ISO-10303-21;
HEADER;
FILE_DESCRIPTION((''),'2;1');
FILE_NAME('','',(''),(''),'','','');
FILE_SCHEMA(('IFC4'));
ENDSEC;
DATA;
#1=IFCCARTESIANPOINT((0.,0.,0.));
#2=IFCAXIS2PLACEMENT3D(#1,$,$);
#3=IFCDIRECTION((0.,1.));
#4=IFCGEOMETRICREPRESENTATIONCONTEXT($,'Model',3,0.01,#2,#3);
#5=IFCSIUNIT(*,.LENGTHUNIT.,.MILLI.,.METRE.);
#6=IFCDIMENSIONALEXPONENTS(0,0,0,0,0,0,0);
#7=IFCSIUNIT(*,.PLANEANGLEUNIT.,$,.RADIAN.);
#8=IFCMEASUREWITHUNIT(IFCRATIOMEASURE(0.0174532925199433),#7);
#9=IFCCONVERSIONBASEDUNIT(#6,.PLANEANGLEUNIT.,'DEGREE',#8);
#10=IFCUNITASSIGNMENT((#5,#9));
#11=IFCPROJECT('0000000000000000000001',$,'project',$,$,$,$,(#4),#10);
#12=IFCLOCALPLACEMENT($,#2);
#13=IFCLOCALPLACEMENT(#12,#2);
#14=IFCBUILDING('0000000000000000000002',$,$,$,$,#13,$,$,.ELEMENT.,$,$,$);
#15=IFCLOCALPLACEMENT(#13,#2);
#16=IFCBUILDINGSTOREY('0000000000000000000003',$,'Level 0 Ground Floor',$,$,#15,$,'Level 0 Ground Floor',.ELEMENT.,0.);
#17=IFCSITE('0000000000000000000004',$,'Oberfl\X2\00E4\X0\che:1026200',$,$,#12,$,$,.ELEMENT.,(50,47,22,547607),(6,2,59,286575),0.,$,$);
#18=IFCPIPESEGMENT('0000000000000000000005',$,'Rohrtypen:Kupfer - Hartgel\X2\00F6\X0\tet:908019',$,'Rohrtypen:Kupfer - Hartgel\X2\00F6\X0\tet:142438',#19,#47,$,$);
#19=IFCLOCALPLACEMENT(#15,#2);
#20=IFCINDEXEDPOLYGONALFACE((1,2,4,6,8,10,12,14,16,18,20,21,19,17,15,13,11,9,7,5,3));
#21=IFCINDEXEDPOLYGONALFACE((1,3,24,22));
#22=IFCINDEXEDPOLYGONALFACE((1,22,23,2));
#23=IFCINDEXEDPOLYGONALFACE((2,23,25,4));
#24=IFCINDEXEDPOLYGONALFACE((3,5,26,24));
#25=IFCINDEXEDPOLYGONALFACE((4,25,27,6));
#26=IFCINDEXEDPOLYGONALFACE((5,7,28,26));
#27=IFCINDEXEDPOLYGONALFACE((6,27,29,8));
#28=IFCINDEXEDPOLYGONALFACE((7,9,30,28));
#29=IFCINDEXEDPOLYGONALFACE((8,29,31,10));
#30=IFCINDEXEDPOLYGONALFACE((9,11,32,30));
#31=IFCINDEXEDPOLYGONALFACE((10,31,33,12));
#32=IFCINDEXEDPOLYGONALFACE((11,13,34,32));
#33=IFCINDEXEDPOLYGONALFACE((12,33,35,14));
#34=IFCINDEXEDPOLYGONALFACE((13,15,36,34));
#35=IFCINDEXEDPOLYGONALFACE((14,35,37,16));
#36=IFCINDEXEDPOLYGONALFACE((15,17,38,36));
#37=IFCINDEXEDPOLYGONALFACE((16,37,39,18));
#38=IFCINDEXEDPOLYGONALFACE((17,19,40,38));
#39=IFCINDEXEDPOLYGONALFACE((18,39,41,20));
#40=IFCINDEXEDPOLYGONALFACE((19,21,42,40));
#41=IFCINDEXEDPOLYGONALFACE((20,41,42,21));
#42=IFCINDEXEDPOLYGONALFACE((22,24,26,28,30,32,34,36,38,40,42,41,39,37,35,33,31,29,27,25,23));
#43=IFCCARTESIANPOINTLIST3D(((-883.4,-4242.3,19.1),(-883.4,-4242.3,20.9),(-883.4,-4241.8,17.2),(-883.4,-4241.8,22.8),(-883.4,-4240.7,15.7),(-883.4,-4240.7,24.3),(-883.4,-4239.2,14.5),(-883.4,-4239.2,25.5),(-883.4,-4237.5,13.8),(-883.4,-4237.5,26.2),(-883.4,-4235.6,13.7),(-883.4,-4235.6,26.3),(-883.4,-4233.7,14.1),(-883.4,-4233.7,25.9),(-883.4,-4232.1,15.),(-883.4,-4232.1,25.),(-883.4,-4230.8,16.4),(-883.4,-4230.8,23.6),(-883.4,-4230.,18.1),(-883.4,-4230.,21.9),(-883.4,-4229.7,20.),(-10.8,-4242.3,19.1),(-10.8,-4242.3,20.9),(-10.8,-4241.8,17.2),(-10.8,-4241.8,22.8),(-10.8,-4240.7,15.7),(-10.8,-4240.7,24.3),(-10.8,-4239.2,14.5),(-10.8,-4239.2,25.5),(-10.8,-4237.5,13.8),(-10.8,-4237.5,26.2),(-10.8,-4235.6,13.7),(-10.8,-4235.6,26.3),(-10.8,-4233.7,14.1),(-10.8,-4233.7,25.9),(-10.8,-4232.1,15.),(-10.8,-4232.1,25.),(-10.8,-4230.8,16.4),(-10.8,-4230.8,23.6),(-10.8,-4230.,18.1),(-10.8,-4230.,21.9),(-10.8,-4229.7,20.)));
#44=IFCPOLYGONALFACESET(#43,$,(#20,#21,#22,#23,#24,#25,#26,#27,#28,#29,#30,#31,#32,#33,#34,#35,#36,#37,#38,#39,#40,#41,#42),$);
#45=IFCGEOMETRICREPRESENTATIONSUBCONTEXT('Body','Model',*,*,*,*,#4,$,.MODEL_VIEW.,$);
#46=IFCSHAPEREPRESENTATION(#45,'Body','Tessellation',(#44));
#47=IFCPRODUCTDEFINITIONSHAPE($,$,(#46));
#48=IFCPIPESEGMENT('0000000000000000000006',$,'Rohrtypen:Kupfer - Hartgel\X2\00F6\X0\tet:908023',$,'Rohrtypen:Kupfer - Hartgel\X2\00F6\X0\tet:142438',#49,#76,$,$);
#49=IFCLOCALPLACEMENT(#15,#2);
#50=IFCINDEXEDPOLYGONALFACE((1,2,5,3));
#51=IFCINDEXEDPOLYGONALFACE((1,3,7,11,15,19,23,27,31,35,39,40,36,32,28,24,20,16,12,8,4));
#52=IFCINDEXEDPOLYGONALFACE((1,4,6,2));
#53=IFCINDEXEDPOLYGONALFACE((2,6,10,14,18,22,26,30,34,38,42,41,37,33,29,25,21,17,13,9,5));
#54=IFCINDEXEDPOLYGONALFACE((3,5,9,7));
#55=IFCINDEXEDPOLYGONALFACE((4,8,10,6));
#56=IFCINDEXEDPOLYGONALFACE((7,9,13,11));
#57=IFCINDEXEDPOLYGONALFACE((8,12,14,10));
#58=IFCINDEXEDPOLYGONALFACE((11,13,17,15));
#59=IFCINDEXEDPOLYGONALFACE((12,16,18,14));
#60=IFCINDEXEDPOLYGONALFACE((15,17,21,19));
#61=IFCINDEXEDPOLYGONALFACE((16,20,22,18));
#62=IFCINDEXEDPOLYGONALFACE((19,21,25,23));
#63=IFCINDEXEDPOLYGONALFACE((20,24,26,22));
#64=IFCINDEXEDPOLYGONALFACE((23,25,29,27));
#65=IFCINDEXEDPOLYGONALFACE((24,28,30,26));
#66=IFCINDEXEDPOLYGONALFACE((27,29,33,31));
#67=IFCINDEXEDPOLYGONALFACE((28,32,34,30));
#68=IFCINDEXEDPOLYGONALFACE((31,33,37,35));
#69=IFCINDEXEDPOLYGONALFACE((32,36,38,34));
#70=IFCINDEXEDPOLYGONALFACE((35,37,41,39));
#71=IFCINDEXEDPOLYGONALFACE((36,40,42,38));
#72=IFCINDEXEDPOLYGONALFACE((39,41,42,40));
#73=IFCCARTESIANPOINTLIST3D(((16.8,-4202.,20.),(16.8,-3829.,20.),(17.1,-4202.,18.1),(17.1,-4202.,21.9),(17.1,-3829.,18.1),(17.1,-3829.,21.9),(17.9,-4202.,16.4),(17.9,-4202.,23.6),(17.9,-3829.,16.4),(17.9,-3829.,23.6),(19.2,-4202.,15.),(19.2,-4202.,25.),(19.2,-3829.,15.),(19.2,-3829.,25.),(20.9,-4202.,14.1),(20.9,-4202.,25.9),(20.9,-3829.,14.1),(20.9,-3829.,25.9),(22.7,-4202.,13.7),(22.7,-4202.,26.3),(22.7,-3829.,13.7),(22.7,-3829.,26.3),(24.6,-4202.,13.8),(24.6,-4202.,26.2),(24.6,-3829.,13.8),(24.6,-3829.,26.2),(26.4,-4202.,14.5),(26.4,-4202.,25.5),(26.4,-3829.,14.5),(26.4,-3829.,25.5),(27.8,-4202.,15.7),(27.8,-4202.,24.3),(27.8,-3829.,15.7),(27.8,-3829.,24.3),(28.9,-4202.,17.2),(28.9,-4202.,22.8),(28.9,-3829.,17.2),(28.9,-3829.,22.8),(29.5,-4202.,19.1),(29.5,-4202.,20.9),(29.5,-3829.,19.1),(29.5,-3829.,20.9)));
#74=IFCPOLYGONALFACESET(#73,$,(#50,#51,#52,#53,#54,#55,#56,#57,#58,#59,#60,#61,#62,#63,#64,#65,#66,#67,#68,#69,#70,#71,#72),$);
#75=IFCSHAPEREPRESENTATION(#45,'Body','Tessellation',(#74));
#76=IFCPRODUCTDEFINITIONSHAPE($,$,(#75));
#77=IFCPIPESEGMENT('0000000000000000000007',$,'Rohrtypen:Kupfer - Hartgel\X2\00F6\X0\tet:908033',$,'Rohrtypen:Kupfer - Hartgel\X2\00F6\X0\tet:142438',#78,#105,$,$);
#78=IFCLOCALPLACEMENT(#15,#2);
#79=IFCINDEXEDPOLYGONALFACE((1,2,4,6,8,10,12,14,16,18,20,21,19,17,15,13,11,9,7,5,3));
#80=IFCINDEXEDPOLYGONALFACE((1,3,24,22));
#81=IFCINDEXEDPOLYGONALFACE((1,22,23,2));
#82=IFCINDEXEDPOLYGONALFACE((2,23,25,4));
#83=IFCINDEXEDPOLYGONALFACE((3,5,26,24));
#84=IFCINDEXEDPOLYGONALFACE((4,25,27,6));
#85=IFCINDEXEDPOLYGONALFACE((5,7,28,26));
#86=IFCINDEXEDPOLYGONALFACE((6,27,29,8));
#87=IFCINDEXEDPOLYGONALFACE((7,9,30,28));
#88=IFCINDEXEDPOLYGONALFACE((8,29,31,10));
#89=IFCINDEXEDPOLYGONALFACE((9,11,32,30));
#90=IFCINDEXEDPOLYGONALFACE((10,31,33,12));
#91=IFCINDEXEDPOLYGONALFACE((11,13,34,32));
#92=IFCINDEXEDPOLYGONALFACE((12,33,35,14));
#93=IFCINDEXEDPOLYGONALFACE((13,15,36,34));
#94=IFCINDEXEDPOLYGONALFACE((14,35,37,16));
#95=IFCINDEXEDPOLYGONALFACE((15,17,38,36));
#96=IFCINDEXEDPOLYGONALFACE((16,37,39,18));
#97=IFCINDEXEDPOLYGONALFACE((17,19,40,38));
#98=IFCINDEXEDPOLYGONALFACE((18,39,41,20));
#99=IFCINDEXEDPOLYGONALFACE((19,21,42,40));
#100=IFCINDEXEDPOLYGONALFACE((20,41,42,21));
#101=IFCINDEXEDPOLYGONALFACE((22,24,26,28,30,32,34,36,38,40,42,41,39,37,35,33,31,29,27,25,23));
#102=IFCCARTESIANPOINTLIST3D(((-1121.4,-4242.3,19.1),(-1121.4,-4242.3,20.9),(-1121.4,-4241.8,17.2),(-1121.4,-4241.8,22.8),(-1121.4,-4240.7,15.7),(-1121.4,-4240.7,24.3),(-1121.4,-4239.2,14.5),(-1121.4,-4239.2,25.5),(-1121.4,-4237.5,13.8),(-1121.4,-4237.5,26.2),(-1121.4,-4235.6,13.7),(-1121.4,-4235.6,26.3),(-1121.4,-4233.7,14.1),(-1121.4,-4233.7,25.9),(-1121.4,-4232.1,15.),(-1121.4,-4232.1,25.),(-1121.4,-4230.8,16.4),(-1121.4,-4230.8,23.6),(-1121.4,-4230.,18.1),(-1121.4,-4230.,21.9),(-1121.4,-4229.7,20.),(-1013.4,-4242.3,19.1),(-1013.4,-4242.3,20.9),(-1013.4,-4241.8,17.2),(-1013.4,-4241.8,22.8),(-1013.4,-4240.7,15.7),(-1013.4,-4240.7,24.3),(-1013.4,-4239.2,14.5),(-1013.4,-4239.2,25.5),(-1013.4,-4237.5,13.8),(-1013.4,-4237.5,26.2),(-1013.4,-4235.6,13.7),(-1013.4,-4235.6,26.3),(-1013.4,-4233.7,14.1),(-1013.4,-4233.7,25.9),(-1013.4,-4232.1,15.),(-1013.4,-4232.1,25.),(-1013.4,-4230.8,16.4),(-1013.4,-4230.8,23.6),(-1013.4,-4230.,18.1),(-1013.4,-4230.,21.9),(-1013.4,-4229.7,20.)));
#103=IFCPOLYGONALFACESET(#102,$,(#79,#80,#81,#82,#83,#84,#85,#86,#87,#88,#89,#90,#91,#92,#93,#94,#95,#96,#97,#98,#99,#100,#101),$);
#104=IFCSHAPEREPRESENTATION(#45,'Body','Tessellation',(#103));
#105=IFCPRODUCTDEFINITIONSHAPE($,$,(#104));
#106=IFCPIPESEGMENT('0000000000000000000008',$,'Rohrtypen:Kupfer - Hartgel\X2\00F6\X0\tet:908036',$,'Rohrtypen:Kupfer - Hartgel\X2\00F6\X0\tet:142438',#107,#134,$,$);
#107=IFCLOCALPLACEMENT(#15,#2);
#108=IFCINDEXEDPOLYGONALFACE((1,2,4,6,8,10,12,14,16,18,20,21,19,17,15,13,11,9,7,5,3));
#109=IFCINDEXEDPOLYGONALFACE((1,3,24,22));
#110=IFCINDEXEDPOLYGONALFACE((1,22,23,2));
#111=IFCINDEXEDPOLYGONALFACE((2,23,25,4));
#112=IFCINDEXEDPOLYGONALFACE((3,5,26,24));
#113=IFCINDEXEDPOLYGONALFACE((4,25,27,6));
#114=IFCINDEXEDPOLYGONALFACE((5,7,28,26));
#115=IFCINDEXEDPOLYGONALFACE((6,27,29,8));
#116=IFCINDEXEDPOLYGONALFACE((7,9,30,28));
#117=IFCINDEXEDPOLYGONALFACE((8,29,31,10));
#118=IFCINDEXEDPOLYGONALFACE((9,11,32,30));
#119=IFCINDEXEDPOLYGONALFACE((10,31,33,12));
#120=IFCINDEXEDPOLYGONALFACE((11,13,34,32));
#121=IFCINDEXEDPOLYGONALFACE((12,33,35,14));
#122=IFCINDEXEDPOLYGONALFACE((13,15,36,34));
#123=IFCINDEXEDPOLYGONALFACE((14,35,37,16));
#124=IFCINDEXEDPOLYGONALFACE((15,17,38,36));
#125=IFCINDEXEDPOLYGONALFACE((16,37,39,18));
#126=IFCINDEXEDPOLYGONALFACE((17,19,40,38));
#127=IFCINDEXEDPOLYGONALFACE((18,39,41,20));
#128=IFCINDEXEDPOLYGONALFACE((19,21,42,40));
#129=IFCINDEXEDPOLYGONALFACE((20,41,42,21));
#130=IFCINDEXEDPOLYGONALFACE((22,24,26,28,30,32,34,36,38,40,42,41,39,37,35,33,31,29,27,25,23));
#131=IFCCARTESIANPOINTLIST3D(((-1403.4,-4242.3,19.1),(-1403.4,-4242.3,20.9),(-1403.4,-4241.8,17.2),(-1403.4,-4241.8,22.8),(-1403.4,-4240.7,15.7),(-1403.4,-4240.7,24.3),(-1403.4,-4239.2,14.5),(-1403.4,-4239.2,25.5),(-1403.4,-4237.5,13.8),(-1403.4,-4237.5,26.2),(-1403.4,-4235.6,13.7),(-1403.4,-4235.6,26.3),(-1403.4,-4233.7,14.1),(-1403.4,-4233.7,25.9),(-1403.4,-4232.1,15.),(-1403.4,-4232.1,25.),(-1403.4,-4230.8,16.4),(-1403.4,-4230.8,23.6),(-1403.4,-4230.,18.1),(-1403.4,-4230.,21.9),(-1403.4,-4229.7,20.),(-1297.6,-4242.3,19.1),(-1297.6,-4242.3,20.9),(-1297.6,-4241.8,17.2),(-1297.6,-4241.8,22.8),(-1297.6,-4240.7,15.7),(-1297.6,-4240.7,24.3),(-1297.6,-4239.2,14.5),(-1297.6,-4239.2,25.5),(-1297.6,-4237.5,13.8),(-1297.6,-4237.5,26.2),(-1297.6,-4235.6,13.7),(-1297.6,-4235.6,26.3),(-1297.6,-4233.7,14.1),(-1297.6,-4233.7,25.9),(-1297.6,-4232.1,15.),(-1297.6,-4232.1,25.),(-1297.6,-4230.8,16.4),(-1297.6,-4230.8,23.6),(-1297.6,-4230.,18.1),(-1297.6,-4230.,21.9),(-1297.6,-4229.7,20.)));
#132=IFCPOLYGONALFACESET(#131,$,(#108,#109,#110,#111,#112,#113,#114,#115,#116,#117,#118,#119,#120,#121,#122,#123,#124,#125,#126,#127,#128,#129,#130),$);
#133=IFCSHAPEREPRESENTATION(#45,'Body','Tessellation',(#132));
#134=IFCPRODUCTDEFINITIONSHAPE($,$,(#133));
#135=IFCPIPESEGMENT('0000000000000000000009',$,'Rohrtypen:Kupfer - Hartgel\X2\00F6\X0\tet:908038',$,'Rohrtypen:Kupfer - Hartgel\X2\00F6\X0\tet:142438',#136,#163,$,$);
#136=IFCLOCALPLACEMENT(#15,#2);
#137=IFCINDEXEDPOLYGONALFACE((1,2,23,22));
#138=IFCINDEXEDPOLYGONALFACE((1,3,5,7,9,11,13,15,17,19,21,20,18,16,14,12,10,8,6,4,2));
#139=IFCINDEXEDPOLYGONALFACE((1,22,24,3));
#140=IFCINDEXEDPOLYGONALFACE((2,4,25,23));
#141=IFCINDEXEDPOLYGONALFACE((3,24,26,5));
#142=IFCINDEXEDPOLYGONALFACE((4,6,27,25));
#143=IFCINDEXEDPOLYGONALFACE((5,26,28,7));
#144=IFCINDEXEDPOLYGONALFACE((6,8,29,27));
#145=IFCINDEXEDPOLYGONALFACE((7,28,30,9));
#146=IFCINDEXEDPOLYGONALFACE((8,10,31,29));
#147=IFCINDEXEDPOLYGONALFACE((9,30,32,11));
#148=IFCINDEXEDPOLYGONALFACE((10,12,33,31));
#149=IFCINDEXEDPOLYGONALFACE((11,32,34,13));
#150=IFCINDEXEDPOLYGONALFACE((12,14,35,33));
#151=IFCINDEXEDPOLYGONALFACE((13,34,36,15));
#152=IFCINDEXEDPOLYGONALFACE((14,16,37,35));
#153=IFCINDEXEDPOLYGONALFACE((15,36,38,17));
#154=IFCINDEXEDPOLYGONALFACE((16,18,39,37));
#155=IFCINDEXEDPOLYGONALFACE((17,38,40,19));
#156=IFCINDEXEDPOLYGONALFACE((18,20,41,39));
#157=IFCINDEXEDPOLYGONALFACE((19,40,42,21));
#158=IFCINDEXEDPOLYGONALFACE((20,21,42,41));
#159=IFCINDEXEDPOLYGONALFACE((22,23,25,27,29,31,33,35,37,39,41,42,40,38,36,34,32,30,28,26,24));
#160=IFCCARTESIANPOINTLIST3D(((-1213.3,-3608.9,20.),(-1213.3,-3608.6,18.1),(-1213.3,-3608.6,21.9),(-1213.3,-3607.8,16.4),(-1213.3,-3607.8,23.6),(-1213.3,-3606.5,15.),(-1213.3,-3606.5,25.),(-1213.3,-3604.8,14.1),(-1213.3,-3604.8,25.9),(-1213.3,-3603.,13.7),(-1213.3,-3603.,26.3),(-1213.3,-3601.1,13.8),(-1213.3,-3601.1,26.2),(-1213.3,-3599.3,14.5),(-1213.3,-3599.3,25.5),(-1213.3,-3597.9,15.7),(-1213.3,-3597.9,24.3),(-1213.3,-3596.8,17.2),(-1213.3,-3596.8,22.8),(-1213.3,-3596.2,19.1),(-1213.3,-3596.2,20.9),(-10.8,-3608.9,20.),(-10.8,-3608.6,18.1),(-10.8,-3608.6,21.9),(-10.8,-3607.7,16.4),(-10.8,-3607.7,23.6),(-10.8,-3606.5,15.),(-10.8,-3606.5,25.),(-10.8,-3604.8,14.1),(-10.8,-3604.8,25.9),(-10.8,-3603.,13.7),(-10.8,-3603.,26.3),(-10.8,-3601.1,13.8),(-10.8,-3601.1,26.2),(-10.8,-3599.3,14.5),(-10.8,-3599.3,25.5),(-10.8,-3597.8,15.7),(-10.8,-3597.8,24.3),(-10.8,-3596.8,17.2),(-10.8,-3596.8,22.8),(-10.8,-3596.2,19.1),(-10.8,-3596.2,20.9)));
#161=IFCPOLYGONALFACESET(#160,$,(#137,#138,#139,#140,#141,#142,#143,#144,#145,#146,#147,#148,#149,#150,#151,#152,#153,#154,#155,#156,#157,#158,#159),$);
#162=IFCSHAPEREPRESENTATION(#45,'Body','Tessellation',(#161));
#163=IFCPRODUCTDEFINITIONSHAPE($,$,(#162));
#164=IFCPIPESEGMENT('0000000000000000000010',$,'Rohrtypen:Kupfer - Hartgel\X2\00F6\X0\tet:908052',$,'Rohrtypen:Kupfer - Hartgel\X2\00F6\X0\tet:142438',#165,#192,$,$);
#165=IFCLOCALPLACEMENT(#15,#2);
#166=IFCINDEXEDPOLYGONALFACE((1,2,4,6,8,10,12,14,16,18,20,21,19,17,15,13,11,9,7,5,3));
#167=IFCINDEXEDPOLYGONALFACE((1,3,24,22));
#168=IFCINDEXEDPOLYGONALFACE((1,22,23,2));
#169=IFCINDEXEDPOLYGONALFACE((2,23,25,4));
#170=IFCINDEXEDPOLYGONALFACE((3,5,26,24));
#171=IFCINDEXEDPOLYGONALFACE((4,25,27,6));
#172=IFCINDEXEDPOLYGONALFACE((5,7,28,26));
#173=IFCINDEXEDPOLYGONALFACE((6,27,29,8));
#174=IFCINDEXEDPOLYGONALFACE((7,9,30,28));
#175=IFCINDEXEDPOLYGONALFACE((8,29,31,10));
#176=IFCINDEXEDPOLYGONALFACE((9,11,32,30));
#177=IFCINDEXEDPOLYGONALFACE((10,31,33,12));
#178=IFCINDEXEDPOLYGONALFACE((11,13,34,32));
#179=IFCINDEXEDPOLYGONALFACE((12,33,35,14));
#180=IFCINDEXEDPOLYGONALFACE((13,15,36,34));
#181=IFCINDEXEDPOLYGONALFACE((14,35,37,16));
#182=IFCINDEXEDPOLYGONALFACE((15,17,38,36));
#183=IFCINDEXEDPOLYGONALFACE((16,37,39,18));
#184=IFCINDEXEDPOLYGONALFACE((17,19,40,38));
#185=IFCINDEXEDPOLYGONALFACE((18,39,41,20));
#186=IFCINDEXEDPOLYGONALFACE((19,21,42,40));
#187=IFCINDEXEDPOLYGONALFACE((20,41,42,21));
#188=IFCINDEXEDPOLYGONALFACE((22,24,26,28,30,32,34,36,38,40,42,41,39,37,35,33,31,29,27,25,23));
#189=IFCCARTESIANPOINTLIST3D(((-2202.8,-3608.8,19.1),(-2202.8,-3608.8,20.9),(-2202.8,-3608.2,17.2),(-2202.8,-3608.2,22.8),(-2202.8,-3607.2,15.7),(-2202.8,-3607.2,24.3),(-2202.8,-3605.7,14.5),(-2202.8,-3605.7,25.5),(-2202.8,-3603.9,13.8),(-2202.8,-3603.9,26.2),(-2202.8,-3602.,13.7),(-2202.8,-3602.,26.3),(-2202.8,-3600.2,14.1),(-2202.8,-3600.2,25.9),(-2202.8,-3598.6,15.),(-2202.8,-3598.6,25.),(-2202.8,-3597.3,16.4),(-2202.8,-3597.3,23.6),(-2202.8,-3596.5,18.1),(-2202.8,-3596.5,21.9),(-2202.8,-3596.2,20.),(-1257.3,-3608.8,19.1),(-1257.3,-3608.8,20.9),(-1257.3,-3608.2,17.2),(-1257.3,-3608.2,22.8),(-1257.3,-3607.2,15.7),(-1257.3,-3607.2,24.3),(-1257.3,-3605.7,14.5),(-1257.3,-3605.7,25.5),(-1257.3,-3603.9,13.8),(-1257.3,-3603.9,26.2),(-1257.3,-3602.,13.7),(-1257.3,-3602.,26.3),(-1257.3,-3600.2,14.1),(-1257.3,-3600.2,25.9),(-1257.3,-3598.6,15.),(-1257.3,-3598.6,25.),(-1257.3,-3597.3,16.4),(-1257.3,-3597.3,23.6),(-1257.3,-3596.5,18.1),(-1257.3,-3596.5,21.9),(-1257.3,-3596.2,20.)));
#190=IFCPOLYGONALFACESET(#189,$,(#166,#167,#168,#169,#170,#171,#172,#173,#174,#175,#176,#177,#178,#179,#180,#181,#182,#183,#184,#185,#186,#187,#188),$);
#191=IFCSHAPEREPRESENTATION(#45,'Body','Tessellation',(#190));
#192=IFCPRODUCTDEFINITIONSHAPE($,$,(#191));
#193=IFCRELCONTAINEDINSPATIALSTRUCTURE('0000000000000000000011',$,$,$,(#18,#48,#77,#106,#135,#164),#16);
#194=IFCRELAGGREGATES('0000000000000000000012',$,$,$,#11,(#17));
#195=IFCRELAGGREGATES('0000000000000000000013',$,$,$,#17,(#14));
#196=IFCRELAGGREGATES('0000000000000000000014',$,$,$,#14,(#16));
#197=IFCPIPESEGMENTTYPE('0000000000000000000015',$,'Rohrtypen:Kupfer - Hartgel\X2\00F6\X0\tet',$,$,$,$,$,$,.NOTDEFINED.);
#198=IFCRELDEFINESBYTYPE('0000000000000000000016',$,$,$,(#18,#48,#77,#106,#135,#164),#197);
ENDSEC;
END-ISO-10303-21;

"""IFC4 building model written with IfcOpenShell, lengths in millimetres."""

from ifc_helpers import new_model, entity, si_unit, converted_unit, direction, frame, frame_2d, origin, place, context, subcontext, project, spatial, circle, extrude, type_object, element, save


model = new_model("IFC4")

# Units and contexts
model_context = context("Model", 3, precision=0.01, world=origin(), true_north=direction((0.0, 1.0)))
body_context = subcontext(model_context, "Body", "Model", "MODEL_VIEW")
ifc_project = project(units=[si_unit("LENGTHUNIT", "METRE", prefix="MILLI"), converted_unit("PLANEANGLEUNIT", "DEGREE", entity("IfcRatioMeasure", 0.0174532925199433), si_unit("PLANEANGLEUNIT", "RADIAN"), dimensions=[0, 0, 0, 0, 0, 0, 0])], contexts=[model_context])

# Site, building, storey
site_placement = place(None, origin())
site = spatial("IfcSite", under=ifc_project, at=site_placement, Name="Oberfläche:1026200", CompositionType="ELEMENT", RefLatitude=(50, 47, 22, 547607), RefLongitude=(6, 2, 59, 286575), RefElevation=0.0)
building_placement = place(site_placement, origin())
building = spatial("IfcBuilding", under=site, at=building_placement, CompositionType="ELEMENT")
storey_placement = place(building_placement, origin())
storey = spatial("IfcBuildingStorey", under=building, at=storey_placement, Name="Level 0 Ground Floor", LongName="Level 0 Ground Floor", CompositionType="ELEMENT", Elevation=0.0)

# Pipe segments
pipe_segment_type = type_object("IfcPipeSegmentType", Name="Rohrtypen:Kupfer - Hartgelötet", PredefinedType="NOTDEFINED")
pipe_segment_1_placement = place(storey_placement, frame((-883.4, -4244.0, 12.1)))
element("IfcPipeSegment", 1, at=pipe_segment_1_placement, inside=storey, type_object=pipe_segment_type, Name="Rohrtypen:Kupfer - Hartgelötet:908019", ObjectType="Rohrtypen:Kupfer - Hartgelötet:142438", context=body_context, shape_type="SweptSolid", body=[
    extrude(circle(Radius=6.3, at=frame_2d((0.0, 0.0), x_axis=(1.0, 0.0))), frame((0.0, 7.9, 7.9), z_axis=(1.0, 0.0, 0.0), x_axis=(0.0, 1.0, 0.0)), (0.0, 0.0, 1.0), 872.6),
])
pipe_segment_2_placement = place(storey_placement, frame((15.2, -4202.0, 12.1)))
element("IfcPipeSegment", 2, at=pipe_segment_2_placement, inside=storey, type_object=pipe_segment_type, Name="Rohrtypen:Kupfer - Hartgelötet:908023", ObjectType="Rohrtypen:Kupfer - Hartgelötet:142438", context=body_context, shape_type="SweptSolid", body=[
    extrude(circle(Radius=6.3, at=frame_2d((0.0, 0.0), x_axis=(1.0, 0.0))), frame((7.9, 0.0, 7.9), z_axis=(0.0, 1.0, 0.0), x_axis=(-1.0, 0.0, 0.0)), (0.0, 0.0, 1.0), 373.0),
])
pipe_segment_3_placement = place(storey_placement, frame((-1121.4, -4244.0, 12.1)))
element("IfcPipeSegment", 3, at=pipe_segment_3_placement, inside=storey, type_object=pipe_segment_type, Name="Rohrtypen:Kupfer - Hartgelötet:908033", ObjectType="Rohrtypen:Kupfer - Hartgelötet:142438", context=body_context, shape_type="SweptSolid", body=[
    extrude(circle(Radius=6.3, at=frame_2d((0.0, 0.0), x_axis=(1.0, 0.0))), frame((0.0, 7.9, 7.9), z_axis=(1.0, 0.0, 0.0), x_axis=(0.0, 1.0, 0.0)), (0.0, 0.0, 1.0), 108.0),
])
pipe_segment_4_placement = place(storey_placement, frame((-1403.4, -4244.0, 12.1)))
element("IfcPipeSegment", 4, at=pipe_segment_4_placement, inside=storey, type_object=pipe_segment_type, Name="Rohrtypen:Kupfer - Hartgelötet:908036", ObjectType="Rohrtypen:Kupfer - Hartgelötet:142438", context=body_context, shape_type="SweptSolid", body=[
    extrude(circle(Radius=6.3, at=frame_2d((0.0, 0.0), x_axis=(1.0, 0.0))), frame((0.0, 7.9, 7.9), z_axis=(1.0, 0.0, 0.0), x_axis=(0.0, 1.0, 0.0)), (0.0, 0.0, 1.0), 105.8),
])
pipe_segment_5_placement = place(storey_placement, frame((-1213.3, -3610.5, 12.1)))
element("IfcPipeSegment", 5, at=pipe_segment_5_placement, inside=storey, type_object=pipe_segment_type, Name="Rohrtypen:Kupfer - Hartgelötet:908038", ObjectType="Rohrtypen:Kupfer - Hartgelötet:142438", context=body_context, shape_type="SweptSolid", body=[
    extrude(circle(Radius=6.3, at=frame_2d((0.0, 0.0), x_axis=(1.0, 0.0))), frame((0.0, 7.9, 7.9), z_axis=(1.0, 0.000017, 0.0), x_axis=(0.000017, -1.0, 0.0)), (0.0, 0.0, 1.0), 1202.5),
])
pipe_segment_6_placement = place(storey_placement, frame((-2202.8, -3610.5, 12.1)))
element("IfcPipeSegment", 6, at=pipe_segment_6_placement, inside=storey, type_object=pipe_segment_type, Name="Rohrtypen:Kupfer - Hartgelötet:908052", ObjectType="Rohrtypen:Kupfer - Hartgelötet:142438", context=body_context, shape_type="SweptSolid", body=[
    extrude(circle(Radius=6.3, at=frame_2d((0.0, 0.0), x_axis=(1.0, 0.0))), frame((0.0, 7.9, 7.9), z_axis=(1.0, 0.0, 0.0), x_axis=(0.0, 1.0, 0.0)), (0.0, 0.0, 1.0), 945.5),
])

save(model, "model.ifc")
